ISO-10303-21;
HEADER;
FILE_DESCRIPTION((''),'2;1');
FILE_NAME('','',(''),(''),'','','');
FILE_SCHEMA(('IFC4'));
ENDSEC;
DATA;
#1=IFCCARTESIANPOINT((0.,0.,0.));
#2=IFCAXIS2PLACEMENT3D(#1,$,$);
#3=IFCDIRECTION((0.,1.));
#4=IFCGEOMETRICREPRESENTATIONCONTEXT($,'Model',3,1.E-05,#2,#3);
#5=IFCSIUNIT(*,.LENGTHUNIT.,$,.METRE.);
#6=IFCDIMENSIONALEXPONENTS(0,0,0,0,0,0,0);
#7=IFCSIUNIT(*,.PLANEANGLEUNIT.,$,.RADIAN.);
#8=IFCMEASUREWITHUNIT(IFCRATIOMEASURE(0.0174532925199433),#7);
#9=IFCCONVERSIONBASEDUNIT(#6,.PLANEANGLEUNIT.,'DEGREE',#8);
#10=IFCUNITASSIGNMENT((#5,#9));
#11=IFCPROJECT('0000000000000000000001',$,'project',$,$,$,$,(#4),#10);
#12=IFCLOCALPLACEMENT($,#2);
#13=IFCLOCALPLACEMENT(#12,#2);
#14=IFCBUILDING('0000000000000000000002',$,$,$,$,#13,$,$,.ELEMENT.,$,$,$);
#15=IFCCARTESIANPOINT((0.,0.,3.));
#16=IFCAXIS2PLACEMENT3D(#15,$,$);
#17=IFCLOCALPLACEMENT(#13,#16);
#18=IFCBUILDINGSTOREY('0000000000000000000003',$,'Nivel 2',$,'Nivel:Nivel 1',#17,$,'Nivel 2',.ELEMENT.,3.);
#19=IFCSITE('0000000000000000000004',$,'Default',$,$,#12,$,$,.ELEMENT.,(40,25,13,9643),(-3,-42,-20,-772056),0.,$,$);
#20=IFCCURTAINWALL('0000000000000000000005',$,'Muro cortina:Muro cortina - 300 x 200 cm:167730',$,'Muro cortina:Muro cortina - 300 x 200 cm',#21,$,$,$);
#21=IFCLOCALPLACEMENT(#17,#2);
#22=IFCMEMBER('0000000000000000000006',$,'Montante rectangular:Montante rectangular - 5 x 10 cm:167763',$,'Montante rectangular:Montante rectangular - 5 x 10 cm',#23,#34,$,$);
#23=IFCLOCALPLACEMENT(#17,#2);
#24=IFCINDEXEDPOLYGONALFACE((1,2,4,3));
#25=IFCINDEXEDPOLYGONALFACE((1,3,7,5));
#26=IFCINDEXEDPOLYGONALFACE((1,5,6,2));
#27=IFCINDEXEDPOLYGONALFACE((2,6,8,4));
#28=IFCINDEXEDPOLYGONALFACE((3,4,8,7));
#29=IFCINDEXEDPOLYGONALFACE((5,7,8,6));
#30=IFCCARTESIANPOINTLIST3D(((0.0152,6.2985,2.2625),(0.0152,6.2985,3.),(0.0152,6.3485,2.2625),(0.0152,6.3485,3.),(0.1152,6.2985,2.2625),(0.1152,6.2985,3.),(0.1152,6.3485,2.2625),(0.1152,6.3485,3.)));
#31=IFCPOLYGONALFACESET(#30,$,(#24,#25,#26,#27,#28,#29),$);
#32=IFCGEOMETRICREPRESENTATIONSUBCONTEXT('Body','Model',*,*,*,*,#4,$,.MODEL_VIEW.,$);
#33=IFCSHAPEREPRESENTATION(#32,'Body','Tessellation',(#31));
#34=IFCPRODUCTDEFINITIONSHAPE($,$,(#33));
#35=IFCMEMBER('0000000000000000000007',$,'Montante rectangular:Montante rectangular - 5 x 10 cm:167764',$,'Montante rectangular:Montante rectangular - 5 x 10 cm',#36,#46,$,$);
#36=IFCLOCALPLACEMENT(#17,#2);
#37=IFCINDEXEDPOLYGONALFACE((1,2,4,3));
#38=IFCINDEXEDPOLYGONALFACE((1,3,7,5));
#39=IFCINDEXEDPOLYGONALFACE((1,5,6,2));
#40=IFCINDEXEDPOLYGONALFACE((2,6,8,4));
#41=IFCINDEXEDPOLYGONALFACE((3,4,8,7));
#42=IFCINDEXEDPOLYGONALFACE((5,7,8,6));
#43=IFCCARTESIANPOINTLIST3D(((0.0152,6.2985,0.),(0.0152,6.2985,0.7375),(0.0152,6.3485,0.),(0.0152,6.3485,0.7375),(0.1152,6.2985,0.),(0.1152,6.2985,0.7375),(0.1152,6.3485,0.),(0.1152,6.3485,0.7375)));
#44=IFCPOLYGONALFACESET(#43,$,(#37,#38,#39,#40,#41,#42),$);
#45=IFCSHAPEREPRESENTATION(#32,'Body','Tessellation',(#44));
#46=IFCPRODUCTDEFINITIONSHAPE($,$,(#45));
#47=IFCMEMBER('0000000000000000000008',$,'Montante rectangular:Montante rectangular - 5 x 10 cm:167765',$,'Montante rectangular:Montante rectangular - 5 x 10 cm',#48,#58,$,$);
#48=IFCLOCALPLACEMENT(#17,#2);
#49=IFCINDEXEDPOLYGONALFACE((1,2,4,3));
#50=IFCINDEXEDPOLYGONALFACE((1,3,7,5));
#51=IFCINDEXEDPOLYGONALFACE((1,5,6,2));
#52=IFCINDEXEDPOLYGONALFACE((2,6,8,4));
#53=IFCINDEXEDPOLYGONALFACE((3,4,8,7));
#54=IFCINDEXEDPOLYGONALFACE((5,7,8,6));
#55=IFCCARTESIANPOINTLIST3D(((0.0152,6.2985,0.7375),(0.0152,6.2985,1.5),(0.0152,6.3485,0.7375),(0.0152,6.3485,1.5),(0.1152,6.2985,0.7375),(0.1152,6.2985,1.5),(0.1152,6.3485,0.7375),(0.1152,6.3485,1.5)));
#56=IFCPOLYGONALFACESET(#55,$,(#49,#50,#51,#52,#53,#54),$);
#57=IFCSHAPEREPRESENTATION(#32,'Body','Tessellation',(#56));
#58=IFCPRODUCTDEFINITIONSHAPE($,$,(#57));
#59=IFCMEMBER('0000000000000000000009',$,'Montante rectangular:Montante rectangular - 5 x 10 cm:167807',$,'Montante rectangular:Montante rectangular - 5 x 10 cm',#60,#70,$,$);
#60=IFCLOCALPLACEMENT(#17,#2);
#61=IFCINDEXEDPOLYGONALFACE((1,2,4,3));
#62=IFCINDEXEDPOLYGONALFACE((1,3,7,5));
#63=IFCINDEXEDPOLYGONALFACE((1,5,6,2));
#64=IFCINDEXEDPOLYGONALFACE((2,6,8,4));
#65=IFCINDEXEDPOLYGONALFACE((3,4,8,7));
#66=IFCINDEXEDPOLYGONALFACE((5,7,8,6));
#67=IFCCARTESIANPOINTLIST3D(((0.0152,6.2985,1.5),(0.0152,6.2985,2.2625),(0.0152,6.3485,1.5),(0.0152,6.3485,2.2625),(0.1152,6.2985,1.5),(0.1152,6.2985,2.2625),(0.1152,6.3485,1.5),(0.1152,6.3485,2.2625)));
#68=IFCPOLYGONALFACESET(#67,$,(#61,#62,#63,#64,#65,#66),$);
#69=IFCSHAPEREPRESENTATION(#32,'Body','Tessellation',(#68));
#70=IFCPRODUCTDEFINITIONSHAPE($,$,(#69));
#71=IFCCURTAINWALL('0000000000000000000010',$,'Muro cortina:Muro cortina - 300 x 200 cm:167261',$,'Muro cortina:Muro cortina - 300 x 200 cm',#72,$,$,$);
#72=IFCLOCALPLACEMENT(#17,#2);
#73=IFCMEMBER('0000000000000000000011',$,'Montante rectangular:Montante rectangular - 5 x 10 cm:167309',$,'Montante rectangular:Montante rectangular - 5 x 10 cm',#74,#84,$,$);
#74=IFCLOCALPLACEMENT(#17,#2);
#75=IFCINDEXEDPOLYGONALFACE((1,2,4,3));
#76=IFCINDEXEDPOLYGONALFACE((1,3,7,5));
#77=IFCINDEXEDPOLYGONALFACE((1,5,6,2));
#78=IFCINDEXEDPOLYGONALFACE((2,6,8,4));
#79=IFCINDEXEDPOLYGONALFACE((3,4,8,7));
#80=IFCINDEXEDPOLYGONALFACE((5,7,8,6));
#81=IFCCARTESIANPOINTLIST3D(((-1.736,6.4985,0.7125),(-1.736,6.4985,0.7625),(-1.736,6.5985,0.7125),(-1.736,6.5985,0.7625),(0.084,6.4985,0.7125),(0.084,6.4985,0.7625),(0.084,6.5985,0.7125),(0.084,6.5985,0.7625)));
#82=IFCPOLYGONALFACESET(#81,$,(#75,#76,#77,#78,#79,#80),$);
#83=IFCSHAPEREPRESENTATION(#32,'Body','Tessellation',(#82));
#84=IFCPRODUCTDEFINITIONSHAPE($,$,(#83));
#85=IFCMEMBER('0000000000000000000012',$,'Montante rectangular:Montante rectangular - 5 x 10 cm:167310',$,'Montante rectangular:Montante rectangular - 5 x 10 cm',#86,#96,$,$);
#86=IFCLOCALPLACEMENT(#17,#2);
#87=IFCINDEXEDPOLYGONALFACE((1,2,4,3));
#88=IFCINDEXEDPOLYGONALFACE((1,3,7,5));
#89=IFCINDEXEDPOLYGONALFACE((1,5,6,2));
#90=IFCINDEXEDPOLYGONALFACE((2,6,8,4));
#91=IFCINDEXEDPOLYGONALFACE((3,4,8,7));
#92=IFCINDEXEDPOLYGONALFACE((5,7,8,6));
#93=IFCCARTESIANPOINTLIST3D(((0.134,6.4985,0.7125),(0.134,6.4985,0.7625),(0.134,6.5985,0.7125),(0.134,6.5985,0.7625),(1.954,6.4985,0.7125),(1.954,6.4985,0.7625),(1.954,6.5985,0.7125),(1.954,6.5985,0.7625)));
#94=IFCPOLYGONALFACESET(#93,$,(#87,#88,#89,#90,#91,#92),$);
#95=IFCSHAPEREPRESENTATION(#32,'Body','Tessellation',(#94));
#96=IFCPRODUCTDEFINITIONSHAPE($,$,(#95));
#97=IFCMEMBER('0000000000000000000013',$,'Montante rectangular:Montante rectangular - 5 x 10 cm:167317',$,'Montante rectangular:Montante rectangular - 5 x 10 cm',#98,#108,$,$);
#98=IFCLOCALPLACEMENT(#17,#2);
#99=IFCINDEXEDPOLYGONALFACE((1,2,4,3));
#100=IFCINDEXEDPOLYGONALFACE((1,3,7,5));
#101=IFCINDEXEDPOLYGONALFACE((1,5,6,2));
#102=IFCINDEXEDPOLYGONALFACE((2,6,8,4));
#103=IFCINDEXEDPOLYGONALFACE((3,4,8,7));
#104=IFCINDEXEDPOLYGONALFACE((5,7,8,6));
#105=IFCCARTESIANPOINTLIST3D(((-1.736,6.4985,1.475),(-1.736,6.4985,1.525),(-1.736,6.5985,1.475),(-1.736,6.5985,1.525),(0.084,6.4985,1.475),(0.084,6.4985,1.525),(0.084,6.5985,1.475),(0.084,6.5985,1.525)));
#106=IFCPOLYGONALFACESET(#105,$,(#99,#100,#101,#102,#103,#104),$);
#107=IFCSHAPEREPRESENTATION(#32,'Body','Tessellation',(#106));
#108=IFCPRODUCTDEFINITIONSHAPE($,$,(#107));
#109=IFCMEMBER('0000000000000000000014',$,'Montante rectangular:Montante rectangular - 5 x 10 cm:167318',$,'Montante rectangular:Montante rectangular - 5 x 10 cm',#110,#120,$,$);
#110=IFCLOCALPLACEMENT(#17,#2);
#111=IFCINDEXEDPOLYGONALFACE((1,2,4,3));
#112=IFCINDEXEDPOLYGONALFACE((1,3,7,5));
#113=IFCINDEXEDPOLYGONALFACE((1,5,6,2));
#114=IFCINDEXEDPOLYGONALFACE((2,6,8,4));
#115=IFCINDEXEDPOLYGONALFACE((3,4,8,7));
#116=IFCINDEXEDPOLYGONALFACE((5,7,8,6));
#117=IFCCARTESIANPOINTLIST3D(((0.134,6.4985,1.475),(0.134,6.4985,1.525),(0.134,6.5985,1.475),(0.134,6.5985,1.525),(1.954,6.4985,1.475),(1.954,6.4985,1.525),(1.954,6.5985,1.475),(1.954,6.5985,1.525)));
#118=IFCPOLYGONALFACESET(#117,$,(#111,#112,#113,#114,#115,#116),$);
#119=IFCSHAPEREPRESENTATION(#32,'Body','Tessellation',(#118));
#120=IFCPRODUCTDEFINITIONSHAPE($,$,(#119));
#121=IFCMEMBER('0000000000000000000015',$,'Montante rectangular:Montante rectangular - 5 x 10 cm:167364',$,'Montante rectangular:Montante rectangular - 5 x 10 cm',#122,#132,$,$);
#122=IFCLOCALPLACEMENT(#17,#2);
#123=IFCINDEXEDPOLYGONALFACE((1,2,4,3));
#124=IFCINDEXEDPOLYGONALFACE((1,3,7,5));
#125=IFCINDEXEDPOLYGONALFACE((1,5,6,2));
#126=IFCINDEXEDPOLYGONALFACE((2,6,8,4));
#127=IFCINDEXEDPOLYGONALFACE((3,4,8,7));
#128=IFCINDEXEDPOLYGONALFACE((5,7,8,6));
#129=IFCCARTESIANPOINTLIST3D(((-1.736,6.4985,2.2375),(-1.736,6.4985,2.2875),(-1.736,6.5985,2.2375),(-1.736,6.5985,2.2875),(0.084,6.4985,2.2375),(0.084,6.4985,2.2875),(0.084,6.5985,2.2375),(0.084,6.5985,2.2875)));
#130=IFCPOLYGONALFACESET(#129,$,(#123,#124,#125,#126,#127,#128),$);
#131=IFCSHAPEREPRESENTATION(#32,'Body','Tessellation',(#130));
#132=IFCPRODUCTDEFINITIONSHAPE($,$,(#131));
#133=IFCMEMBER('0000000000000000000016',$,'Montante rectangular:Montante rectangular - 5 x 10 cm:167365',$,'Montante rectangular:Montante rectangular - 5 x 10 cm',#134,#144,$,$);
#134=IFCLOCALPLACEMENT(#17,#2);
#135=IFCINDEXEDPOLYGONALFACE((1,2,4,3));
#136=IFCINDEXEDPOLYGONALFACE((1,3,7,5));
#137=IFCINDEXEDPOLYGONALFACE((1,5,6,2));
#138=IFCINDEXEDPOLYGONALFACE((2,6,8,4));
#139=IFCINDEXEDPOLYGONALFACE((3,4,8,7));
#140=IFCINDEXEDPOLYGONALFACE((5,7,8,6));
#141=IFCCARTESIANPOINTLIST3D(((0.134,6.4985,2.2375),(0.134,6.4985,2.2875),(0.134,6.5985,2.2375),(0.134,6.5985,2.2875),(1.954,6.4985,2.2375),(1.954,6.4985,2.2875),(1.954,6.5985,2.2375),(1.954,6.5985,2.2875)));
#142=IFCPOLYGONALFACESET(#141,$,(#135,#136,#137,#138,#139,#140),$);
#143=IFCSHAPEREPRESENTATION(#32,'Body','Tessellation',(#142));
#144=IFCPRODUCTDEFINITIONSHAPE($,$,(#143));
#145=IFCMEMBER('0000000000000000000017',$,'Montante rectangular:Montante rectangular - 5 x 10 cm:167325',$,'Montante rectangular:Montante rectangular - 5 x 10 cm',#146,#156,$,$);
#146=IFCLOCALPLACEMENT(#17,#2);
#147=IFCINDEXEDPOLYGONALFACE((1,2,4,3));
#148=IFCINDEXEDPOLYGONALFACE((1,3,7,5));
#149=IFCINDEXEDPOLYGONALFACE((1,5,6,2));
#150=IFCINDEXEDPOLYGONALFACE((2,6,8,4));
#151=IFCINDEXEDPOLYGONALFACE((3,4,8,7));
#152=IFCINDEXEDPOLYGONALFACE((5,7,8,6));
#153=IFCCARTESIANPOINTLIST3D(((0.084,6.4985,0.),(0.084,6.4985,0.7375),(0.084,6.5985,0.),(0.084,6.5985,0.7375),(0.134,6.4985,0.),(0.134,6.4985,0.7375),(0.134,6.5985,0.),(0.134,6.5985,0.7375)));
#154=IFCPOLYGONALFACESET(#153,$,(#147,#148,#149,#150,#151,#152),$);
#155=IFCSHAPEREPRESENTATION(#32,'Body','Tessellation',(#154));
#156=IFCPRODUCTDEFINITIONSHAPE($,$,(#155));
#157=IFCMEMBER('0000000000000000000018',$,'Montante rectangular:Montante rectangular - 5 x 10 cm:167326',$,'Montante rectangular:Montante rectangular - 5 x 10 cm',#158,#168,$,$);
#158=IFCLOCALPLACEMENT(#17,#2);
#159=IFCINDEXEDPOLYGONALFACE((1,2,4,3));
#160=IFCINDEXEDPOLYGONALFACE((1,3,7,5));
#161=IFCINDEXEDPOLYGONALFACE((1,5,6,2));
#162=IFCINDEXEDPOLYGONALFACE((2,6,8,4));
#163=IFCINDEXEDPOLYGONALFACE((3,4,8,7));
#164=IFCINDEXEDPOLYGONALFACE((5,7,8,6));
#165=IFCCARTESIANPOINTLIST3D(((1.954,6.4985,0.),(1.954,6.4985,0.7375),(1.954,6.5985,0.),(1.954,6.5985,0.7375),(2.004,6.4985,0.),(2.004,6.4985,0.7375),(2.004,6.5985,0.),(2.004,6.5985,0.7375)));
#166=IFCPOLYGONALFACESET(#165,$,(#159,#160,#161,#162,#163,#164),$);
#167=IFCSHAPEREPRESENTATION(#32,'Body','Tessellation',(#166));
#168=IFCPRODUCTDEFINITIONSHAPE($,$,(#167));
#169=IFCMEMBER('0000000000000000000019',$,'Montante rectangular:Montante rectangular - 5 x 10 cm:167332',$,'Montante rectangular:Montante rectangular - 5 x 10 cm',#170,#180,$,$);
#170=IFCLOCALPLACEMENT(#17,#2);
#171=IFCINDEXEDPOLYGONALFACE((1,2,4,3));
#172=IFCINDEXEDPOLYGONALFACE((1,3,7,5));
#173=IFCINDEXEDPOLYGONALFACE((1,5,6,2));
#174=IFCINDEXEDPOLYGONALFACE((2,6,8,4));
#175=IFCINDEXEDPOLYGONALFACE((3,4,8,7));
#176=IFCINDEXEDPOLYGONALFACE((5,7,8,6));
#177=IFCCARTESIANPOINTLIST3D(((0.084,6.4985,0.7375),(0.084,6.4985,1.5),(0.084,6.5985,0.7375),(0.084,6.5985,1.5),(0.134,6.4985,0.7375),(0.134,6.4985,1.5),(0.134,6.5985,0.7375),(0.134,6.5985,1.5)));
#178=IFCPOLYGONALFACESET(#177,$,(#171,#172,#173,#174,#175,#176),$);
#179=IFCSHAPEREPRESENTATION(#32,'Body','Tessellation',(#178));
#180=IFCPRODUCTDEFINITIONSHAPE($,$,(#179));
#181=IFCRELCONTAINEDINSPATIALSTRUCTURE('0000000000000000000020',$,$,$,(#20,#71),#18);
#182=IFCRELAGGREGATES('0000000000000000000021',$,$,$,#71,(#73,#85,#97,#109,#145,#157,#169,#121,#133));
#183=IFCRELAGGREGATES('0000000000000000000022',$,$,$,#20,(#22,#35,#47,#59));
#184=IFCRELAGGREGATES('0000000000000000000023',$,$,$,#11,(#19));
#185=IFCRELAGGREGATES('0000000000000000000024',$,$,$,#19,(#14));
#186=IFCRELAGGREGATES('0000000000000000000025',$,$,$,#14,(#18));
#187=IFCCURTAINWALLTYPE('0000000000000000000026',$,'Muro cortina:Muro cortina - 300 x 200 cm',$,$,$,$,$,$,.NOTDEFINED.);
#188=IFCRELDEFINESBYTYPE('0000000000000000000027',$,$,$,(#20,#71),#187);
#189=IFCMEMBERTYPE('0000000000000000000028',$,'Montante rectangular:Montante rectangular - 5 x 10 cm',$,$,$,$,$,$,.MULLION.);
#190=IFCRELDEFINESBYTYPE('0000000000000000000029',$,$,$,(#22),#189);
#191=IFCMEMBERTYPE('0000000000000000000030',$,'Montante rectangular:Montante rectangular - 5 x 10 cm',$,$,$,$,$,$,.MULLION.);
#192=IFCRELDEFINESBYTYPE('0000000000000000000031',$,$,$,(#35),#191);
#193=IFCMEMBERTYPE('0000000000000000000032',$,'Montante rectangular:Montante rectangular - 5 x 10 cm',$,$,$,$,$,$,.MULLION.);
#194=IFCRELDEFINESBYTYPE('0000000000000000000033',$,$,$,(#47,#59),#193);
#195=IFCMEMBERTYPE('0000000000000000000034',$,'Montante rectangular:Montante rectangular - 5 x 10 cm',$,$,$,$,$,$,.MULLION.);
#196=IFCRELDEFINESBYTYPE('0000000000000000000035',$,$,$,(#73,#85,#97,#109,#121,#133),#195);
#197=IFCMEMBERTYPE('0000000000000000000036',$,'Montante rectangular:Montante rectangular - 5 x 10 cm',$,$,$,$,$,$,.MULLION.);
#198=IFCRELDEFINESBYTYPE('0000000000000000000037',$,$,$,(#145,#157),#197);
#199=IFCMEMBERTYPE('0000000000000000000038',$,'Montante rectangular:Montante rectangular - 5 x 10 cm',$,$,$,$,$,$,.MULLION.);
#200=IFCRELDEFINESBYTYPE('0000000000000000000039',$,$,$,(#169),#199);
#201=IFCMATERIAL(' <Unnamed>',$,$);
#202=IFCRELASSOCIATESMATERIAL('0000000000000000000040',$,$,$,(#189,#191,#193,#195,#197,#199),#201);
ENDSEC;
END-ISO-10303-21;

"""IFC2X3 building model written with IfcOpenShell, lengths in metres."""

from ifc_helpers import new_model, entity, si_unit, converted_unit, direction, frame, origin, origin_2d_with_axis, place, context, subcontext, project, spatial, rectangle, extrude, source, transform, mapped, material, type_object, type_shapes, element, aggregate, save


model = new_model("IFC2X3")

# Units and contexts
model_context = context("Model", 3, precision=1e-05, world=origin(), true_north=direction((0.0, 1.0)))
body_context = subcontext(model_context, "Body", "Model", "MODEL_VIEW")
ifc_project = project(units=[si_unit("LENGTHUNIT", "METRE"), converted_unit("PLANEANGLEUNIT", "DEGREE", entity("IfcRatioMeasure", 0.0174532925199433), si_unit("PLANEANGLEUNIT", "RADIAN"), dimensions=[0, 0, 0, 0, 0, 0, 0])], contexts=[model_context])

# Site, building, storey
site_placement = place(None, origin())
site = spatial("IfcSite", under=ifc_project, at=site_placement, Name="Default", CompositionType="ELEMENT", RefLatitude=(40, 25, 13, 9643), RefLongitude=(-3, -42, -20, -772056), RefElevation=0.0)
building_placement = place(site_placement, origin())
building = spatial("IfcBuilding", under=site, at=building_placement, CompositionType="ELEMENT")
storey_placement = place(building_placement, frame((0.0, 0.0, 3.0)))
storey = spatial("IfcBuildingStorey", under=building, at=storey_placement, Name="Nivel 2", ObjectType="Nivel:Nivel 1", LongName="Nivel 2", CompositionType="ELEMENT", Elevation=3.0)

# Curtain walls, members
curtain_wall_type = type_object("IfcCurtainWallType", Name="Muro cortina:Muro cortina - 300 x 200 cm", PredefinedType="NOTDEFINED")
curtain_wall_1_placement = place(storey_placement, frame((0.0, 0.0, -3.0)))
curtain_wall_1 = element("IfcCurtainWall", 1, at=curtain_wall_1_placement, inside=storey, type_object=curtain_wall_type, Name="Muro cortina:Muro cortina - 300 x 200 cm:167730", ObjectType="Muro cortina:Muro cortina - 300 x 200 cm")
ifc_material_1 = material(Name=" <Unnamed>")
member_type_1 = type_object("IfcMemberType", Name="Montante rectangular:Montante rectangular - 5 x 10 cm", PredefinedType="MULLION", material=ifc_material_1)
shared_shape_1 = source(origin(), body_context, "Body", "SweptSolid", [
    extrude(rectangle(XDim=0.1, YDim=0.05, at=origin_2d_with_axis()), frame((-0.025, 0.0, -0.7375), z_axis=(0.0, 0.0, 1.0), x_axis=(0.0, -1.0, 0.0)), (0.0, 0.0, 1.0), 0.7375),
])
type_shapes(member_type_1, [shared_shape_1])
member_1_placement = place(storey_placement, frame((0.0652, 6.3485, 3.0), z_axis=(0.0, 0.0, 1.0), x_axis=(0.0, 1.0, 0.0)))
member_1 = element("IfcMember", 2, at=member_1_placement, type_object=member_type_1, Name="Montante rectangular:Montante rectangular - 5 x 10 cm:167763", ObjectType="Montante rectangular:Montante rectangular - 5 x 10 cm", context=body_context, shape_type="MappedRepresentation", body=[
    mapped(shared_shape_1, transform((0.0, 0.0, 0.0), scale=1.0)),
])
member_type_2 = type_object("IfcMemberType", Name="Montante rectangular:Montante rectangular - 5 x 10 cm", PredefinedType="MULLION", material=ifc_material_1)
shared_shape_2 = source(origin(), body_context, "Body", "SweptSolid", [
    extrude(rectangle(XDim=0.1, YDim=0.05, at=origin_2d_with_axis()), frame((-0.025, 0.0, -0.7375), z_axis=(0.0, 0.0, 1.0), x_axis=(0.0, -1.0, 0.0)), (0.0, 0.0, 1.0), 0.7375),
])
type_shapes(member_type_2, [shared_shape_2])
member_2_placement = place(storey_placement, frame((0.0652, 6.3485, 0.7375), z_axis=(0.0, 0.0, 1.0), x_axis=(0.0, 1.0, 0.0)))
member_2 = element("IfcMember", 3, at=member_2_placement, type_object=member_type_2, Name="Montante rectangular:Montante rectangular - 5 x 10 cm:167764", ObjectType="Montante rectangular:Montante rectangular - 5 x 10 cm", context=body_context, shape_type="MappedRepresentation", body=[
    mapped(shared_shape_2, transform((0.0, 0.0, 0.0), scale=1.0)),
])
member_type_3 = type_object("IfcMemberType", Name="Montante rectangular:Montante rectangular - 5 x 10 cm", PredefinedType="MULLION", material=ifc_material_1)
shared_shape_3 = source(origin(), body_context, "Body", "SweptSolid", [
    extrude(rectangle(XDim=0.1, YDim=0.05, at=origin_2d_with_axis()), frame((-0.025, 0.0, -0.7625), z_axis=(0.0, 0.0, 1.0), x_axis=(0.0, -1.0, 0.0)), (0.0, 0.0, 1.0), 0.7625),
])
type_shapes(member_type_3, [shared_shape_3])
member_3_placement = place(storey_placement, frame((0.0652, 6.3485, 1.5), z_axis=(0.0, 0.0, 1.0), x_axis=(0.0, 1.0, 0.0)))
member_3 = element("IfcMember", 4, at=member_3_placement, type_object=member_type_3, Name="Montante rectangular:Montante rectangular - 5 x 10 cm:167765", ObjectType="Montante rectangular:Montante rectangular - 5 x 10 cm", context=body_context, shape_type="MappedRepresentation", body=[
    mapped(shared_shape_3, transform((0.0, 0.0, 0.0), scale=1.0)),
])
member_4_placement = place(storey_placement, frame((0.0652, 6.3485, 2.2625), z_axis=(0.0, 0.0, 1.0), x_axis=(0.0, 1.0, 0.0)))
member_4 = element("IfcMember", 5, at=member_4_placement, type_object=member_type_3, Name="Montante rectangular:Montante rectangular - 5 x 10 cm:167807", ObjectType="Montante rectangular:Montante rectangular - 5 x 10 cm", context=body_context, shape_type="MappedRepresentation", body=[
    mapped(shared_shape_3, transform((0.0, 0.0, 0.0), scale=1.0)),
])
curtain_wall_2_placement = place(storey_placement, frame((0.0, 0.0, -3.0)))
curtain_wall_2 = element("IfcCurtainWall", 6, at=curtain_wall_2_placement, inside=storey, type_object=curtain_wall_type, Name="Muro cortina:Muro cortina - 300 x 200 cm:167261", ObjectType="Muro cortina:Muro cortina - 300 x 200 cm")
member_type_4 = type_object("IfcMemberType", Name="Montante rectangular:Montante rectangular - 5 x 10 cm", PredefinedType="MULLION", material=ifc_material_1)
shared_shape_4 = source(origin(), body_context, "Body", "SweptSolid", [
    extrude(rectangle(XDim=0.1, YDim=0.05, at=origin_2d_with_axis()), frame((0.0, 0.0, -1.82), z_axis=(0.0, 0.0, 1.0), x_axis=(0.0, -1.0, 0.0)), (0.0, 0.0, 1.0), 1.82),
])
type_shapes(member_type_4, [shared_shape_4])
member_5_placement = place(storey_placement, frame((0.084, 6.5485, 0.7375), z_axis=(1.0, 0.0, 0.0), x_axis=(0.0, 0.0, 1.0)))
member_5 = element("IfcMember", 7, at=member_5_placement, type_object=member_type_4, Name="Montante rectangular:Montante rectangular - 5 x 10 cm:167309", ObjectType="Montante rectangular:Montante rectangular - 5 x 10 cm", context=body_context, shape_type="MappedRepresentation", body=[
    mapped(shared_shape_4, transform((0.0, 0.0, 0.0), scale=1.0)),
])
member_6_placement = place(storey_placement, frame((1.954, 6.5485, 0.7375), z_axis=(1.0, 0.0, 0.0), x_axis=(0.0, 0.0, 1.0)))
member_6 = element("IfcMember", 8, at=member_6_placement, type_object=member_type_4, Name="Montante rectangular:Montante rectangular - 5 x 10 cm:167310", ObjectType="Montante rectangular:Montante rectangular - 5 x 10 cm", context=body_context, shape_type="MappedRepresentation", body=[
    mapped(shared_shape_4, transform((0.0, 0.0, 0.0), scale=1.0)),
])
member_7_placement = place(storey_placement, frame((0.084, 6.5485, 1.5), z_axis=(1.0, 0.0, 0.0), x_axis=(0.0, 0.0, 1.0)))
member_7 = element("IfcMember", 9, at=member_7_placement, type_object=member_type_4, Name="Montante rectangular:Montante rectangular - 5 x 10 cm:167317", ObjectType="Montante rectangular:Montante rectangular - 5 x 10 cm", context=body_context, shape_type="MappedRepresentation", body=[
    mapped(shared_shape_4, transform((0.0, 0.0, 0.0), scale=1.0)),
])
member_8_placement = place(storey_placement, frame((1.954, 6.5485, 1.5), z_axis=(1.0, 0.0, 0.0), x_axis=(0.0, 0.0, 1.0)))
member_8 = element("IfcMember", 10, at=member_8_placement, type_object=member_type_4, Name="Montante rectangular:Montante rectangular - 5 x 10 cm:167318", ObjectType="Montante rectangular:Montante rectangular - 5 x 10 cm", context=body_context, shape_type="MappedRepresentation", body=[
    mapped(shared_shape_4, transform((0.0, 0.0, 0.0), scale=1.0)),
])
member_9_placement = place(storey_placement, frame((0.084, 6.5485, 2.2625), z_axis=(1.0, 0.0, 0.0), x_axis=(0.0, 0.0, 1.0)))
member_9 = element("IfcMember", 11, at=member_9_placement, type_object=member_type_4, Name="Montante rectangular:Montante rectangular - 5 x 10 cm:167364", ObjectType="Montante rectangular:Montante rectangular - 5 x 10 cm", context=body_context, shape_type="MappedRepresentation", body=[
    mapped(shared_shape_4, transform((0.0, 0.0, 0.0), scale=1.0)),
])
member_10_placement = place(storey_placement, frame((1.954, 6.5485, 2.2625), z_axis=(1.0, 0.0, 0.0), x_axis=(0.0, 0.0, 1.0)))
member_10 = element("IfcMember", 12, at=member_10_placement, type_object=member_type_4, Name="Montante rectangular:Montante rectangular - 5 x 10 cm:167365", ObjectType="Montante rectangular:Montante rectangular - 5 x 10 cm", context=body_context, shape_type="MappedRepresentation", body=[
    mapped(shared_shape_4, transform((0.0, 0.0, 0.0), scale=1.0)),
])
member_type_5 = type_object("IfcMemberType", Name="Montante rectangular:Montante rectangular - 5 x 10 cm", PredefinedType="MULLION", material=ifc_material_1)
shared_shape_5 = source(origin(), body_context, "Body", "SweptSolid", [
    extrude(rectangle(XDim=0.1, YDim=0.05, at=origin_2d_with_axis()), frame((0.0, 0.0, -0.7375), z_axis=(0.0, 0.0, 1.0), x_axis=(0.0, -1.0, 0.0)), (0.0, 0.0, 1.0), 0.7375),
])
type_shapes(member_type_5, [shared_shape_5])
member_11_placement = place(storey_placement, frame((0.109, 6.5485, 0.0), z_axis=(0.0, 0.0, -1.0), x_axis=(1.0, 0.0, 0.0)))
member_11 = element("IfcMember", 13, at=member_11_placement, type_object=member_type_5, Name="Montante rectangular:Montante rectangular - 5 x 10 cm:167325", ObjectType="Montante rectangular:Montante rectangular - 5 x 10 cm", context=body_context, shape_type="MappedRepresentation", body=[
    mapped(shared_shape_5, transform((0.0, 0.0, 0.0), scale=1.0)),
])
member_12_placement = place(storey_placement, frame((1.979, 6.5485, 0.0), z_axis=(0.0, 0.0, -1.0), x_axis=(1.0, 0.0, 0.0)))
member_12 = element("IfcMember", 14, at=member_12_placement, type_object=member_type_5, Name="Montante rectangular:Montante rectangular - 5 x 10 cm:167326", ObjectType="Montante rectangular:Montante rectangular - 5 x 10 cm", context=body_context, shape_type="MappedRepresentation", body=[
    mapped(shared_shape_5, transform((0.0, 0.0, 0.0), scale=1.0)),
])
member_type_6 = type_object("IfcMemberType", Name="Montante rectangular:Montante rectangular - 5 x 10 cm", PredefinedType="MULLION", material=ifc_material_1)
shared_shape_6 = source(origin(), body_context, "Body", "SweptSolid", [
    extrude(rectangle(XDim=0.1, YDim=0.05, at=origin_2d_with_axis()), frame((0.0, 0.0, -0.7625), z_axis=(0.0, 0.0, 1.0), x_axis=(0.0, -1.0, 0.0)), (0.0, 0.0, 1.0), 0.7625),
])
type_shapes(member_type_6, [shared_shape_6])
member_13_placement = place(storey_placement, frame((0.109, 6.5485, 0.7375), z_axis=(0.0, 0.0, -1.0), x_axis=(1.0, 0.0, 0.0)))
member_13 = element("IfcMember", 15, at=member_13_placement, type_object=member_type_6, Name="Montante rectangular:Montante rectangular - 5 x 10 cm:167332", ObjectType="Montante rectangular:Montante rectangular - 5 x 10 cm", context=body_context, shape_type="MappedRepresentation", body=[
    mapped(shared_shape_6, transform((0.0, 0.0, 0.0), scale=1.0)),
])

aggregate(curtain_wall_2, [member_5, member_6, member_7, member_8, member_11, member_12, member_13, member_9, member_10])
aggregate(curtain_wall_1, [member_1, member_2, member_3, member_4])

save(model, "model.ifc")
